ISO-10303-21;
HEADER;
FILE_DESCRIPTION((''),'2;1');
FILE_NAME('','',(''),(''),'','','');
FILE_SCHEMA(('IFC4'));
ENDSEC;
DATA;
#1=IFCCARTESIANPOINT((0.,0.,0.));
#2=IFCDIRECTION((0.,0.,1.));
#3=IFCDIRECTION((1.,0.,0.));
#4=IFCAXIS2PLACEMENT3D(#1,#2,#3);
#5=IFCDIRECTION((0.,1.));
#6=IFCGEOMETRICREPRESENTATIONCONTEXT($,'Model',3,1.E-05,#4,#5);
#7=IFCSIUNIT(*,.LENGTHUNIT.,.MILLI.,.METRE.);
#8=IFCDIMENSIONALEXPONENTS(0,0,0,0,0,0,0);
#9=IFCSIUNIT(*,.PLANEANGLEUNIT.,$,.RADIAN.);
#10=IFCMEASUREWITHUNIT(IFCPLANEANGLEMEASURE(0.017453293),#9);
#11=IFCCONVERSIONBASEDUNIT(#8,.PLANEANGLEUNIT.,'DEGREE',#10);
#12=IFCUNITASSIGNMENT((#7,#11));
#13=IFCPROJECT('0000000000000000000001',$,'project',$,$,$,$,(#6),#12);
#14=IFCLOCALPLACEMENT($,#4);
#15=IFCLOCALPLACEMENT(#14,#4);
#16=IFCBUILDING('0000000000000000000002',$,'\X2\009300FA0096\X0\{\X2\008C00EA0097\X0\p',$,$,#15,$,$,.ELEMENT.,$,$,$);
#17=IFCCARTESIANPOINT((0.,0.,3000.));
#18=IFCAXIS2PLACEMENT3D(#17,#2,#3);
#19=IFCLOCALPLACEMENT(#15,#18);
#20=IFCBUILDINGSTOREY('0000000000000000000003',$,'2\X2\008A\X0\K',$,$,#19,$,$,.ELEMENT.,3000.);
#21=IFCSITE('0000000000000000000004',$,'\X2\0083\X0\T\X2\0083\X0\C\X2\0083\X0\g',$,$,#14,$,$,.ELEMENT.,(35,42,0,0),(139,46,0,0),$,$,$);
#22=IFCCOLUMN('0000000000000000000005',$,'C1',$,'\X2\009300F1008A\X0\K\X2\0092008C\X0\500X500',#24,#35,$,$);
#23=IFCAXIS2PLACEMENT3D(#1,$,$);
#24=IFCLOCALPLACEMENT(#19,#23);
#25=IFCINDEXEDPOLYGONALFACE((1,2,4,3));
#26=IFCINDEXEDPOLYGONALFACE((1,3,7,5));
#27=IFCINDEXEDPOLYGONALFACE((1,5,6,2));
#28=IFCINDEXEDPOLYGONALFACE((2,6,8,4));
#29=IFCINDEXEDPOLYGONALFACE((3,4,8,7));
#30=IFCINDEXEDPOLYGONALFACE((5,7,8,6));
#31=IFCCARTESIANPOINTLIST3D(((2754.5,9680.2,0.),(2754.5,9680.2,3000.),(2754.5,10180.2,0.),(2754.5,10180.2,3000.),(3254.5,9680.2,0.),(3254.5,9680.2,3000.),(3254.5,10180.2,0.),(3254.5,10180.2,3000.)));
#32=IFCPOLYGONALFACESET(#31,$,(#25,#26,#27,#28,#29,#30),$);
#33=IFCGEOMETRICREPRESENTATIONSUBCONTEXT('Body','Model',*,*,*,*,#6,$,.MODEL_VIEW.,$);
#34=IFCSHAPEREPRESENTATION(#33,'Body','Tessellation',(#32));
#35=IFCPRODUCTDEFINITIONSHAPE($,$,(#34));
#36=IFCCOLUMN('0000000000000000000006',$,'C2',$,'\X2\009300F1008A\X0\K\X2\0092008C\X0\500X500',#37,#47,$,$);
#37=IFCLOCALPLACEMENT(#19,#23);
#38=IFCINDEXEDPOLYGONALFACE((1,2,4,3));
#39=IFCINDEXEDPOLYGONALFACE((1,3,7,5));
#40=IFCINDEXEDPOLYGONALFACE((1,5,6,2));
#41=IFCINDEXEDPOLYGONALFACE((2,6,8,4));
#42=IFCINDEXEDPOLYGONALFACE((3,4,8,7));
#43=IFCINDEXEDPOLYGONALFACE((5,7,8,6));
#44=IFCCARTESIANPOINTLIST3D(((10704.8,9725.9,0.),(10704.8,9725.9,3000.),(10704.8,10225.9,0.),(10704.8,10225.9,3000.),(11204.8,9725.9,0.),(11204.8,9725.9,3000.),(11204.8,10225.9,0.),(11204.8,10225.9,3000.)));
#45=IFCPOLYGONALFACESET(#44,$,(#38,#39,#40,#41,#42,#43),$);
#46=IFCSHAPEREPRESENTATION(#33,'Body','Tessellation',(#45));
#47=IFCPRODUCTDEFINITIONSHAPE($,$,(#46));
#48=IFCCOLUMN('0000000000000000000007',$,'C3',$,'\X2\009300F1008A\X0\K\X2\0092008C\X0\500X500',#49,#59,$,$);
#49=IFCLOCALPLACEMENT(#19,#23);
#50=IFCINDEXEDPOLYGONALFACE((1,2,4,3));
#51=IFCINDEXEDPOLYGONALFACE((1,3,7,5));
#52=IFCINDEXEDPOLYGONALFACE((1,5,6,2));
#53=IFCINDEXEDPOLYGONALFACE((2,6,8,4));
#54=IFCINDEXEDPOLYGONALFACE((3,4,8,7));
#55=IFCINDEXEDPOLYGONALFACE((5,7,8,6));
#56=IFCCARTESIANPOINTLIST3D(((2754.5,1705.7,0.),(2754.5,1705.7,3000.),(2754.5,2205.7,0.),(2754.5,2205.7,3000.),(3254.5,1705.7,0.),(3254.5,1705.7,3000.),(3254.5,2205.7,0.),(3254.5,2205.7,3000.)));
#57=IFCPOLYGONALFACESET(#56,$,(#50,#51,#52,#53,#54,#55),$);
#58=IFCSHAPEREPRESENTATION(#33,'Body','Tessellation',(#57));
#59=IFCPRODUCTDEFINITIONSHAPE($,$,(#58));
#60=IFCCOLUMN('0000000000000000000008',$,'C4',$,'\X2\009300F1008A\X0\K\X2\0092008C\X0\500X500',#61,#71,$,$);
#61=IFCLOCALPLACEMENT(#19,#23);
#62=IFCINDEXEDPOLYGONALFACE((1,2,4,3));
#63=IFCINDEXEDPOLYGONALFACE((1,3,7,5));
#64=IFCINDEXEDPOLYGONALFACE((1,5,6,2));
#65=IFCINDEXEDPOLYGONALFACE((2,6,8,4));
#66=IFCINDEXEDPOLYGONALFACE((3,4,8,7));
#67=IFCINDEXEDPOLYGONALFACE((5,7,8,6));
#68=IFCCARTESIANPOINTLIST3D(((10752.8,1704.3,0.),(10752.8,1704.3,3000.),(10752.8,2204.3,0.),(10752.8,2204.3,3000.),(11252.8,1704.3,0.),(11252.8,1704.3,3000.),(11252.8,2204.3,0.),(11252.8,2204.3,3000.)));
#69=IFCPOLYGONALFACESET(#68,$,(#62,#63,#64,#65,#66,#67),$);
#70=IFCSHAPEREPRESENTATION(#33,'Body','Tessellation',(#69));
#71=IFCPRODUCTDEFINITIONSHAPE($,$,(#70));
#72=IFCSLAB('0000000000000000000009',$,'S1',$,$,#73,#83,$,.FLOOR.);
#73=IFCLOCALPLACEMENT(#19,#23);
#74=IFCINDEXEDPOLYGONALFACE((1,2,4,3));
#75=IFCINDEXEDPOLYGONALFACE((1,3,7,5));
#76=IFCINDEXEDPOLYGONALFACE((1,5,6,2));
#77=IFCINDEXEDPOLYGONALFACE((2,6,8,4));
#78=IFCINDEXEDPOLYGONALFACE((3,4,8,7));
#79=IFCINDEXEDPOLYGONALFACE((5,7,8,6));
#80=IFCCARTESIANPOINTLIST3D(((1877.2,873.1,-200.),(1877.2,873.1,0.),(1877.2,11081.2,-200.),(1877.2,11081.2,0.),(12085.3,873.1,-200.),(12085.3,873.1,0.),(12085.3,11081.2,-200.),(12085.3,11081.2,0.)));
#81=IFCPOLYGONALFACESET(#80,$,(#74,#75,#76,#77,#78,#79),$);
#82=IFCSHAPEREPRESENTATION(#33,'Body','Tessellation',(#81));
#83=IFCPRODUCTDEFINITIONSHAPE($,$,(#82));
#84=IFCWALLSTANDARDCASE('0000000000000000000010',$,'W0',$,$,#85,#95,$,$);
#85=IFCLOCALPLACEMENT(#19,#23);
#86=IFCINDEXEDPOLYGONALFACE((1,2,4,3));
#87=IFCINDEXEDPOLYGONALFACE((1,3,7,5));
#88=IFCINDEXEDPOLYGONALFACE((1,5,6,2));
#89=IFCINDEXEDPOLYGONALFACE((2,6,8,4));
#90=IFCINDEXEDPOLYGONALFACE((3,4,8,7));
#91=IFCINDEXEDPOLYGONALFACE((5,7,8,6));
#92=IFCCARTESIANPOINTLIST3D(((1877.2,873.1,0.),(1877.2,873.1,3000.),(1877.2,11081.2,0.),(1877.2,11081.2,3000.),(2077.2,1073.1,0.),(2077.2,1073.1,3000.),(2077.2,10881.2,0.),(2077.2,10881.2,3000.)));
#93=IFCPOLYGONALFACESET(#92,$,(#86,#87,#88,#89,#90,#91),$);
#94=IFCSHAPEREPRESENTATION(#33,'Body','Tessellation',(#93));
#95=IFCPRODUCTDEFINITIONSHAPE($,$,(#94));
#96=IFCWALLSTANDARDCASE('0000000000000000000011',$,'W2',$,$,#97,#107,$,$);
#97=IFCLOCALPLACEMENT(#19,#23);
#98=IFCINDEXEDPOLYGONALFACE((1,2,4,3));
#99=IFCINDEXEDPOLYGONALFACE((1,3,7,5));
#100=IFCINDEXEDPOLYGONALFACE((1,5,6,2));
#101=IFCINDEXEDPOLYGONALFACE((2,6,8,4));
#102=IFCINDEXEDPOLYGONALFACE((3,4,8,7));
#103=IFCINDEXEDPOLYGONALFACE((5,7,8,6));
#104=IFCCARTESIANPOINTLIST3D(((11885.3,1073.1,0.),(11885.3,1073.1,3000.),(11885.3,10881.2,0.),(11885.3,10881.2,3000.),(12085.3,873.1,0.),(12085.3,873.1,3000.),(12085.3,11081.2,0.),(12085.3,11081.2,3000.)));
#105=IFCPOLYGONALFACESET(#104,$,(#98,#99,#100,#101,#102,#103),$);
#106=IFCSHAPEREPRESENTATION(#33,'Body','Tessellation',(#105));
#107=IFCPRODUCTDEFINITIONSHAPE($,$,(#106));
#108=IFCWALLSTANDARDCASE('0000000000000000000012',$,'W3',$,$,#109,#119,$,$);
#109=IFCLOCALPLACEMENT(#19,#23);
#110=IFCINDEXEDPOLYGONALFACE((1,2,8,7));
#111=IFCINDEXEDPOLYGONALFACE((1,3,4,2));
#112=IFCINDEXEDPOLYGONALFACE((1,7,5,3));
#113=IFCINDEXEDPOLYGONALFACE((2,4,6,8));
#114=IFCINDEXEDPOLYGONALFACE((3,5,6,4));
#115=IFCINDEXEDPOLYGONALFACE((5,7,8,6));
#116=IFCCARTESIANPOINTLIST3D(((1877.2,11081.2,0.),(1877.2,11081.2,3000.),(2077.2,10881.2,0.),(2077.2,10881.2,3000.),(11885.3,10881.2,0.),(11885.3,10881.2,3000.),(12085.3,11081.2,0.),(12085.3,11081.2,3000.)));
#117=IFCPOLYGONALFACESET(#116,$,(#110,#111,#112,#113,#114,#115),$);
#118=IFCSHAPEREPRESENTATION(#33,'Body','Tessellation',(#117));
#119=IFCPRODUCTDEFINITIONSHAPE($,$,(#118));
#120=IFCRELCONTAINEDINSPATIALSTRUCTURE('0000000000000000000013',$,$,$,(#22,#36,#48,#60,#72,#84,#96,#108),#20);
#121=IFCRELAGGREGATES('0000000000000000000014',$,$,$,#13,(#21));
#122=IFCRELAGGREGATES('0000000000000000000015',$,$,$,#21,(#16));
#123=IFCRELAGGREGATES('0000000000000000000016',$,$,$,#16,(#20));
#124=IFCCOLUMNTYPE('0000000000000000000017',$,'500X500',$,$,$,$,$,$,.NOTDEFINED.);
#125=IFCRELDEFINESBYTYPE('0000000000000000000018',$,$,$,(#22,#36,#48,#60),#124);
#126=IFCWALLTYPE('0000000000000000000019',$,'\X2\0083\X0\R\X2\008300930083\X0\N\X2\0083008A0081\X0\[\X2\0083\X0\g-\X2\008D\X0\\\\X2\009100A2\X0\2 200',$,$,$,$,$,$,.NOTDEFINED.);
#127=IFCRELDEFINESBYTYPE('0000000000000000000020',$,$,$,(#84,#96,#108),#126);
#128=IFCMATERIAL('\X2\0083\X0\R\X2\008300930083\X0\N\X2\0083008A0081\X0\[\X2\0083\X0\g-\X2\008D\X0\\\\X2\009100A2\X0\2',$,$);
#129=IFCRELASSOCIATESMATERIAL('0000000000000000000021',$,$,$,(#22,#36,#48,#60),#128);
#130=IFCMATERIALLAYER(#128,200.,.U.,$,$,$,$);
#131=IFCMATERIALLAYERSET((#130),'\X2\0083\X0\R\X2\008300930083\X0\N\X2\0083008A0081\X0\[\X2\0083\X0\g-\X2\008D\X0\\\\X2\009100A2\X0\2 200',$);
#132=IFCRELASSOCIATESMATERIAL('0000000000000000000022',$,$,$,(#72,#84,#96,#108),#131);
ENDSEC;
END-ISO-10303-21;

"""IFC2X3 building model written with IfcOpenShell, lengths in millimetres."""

from ifc_helpers import new_model, entity, si_unit, converted_unit, direction, frame, origin_with_axes, origin_2d_with_axis, place, context, subcontext, project, spatial, polyline, rectangle, outline, extrude, material, layer, layer_set, layer_usage, type_object, element, save


model = new_model("IFC2X3")

# Units and contexts
model_context = context("Model", 3, precision=1e-05, world=origin_with_axes(), true_north=direction((0.0, 1.0)))
body_context = subcontext(model_context, "Body", "Model", "MODEL_VIEW")
ifc_project = project(units=[si_unit("LENGTHUNIT", "METRE", prefix="MILLI"), converted_unit("PLANEANGLEUNIT", "DEGREE", entity("IfcPlaneAngleMeasure", 0.017453293), si_unit("PLANEANGLEUNIT", "RADIAN"), dimensions=[0, 0, 0, 0, 0, 0, 0])], contexts=[model_context])

# Site, building, storey
site_placement = place(None, origin_with_axes())
site = spatial("IfcSite", under=ifc_project, at=site_placement, Name="\u0083T\u0083C\u0083g", CompositionType="ELEMENT", RefLatitude=(35, 42, 0, 0), RefLongitude=(139, 46, 0, 0))
building_placement = place(site_placement, origin_with_axes())
building = spatial("IfcBuilding", under=site, at=building_placement, Name="\u0093ú\u0096{\u008cê\u0097p", CompositionType="ELEMENT")
storey_placement = place(building_placement, frame((0.0, 0.0, 3000.0), z_axis=(0.0, 0.0, 1.0), x_axis=(1.0, 0.0, 0.0)))
storey = spatial("IfcBuildingStorey", under=building, at=storey_placement, Name="2\u008aK", CompositionType="ELEMENT", Elevation=3000.0)

# Columns
ifc_material = material(Name="\u0083R\u0083\u0093\u0083N\u0083\u008a\u0081[\u0083g-\u008d\\\u0091¢2")
column_type = type_object("IfcColumnType", Name="500X500", PredefinedType="NOTDEFINED")
for number, where, z_axis, x_axis, name in (
    (1, (3004.5, 9930.2, 0.0), (0.0, 0.0, 1.0), (1.0, 0.0, 0.0), "C1"),
    (2, (10954.8, 9975.9, 0.0), (0.0, 0.0, 1.0), (1.0, 0.0, 0.0), "C2"),
    (3, (3004.5, 1955.7, 0.0), (0.0, 0.0, 1.0), (1.0, 0.0, 0.0), "C3"),
    (4, (11002.8, 1954.3, 0.0), (0.0, 0.0, 1.0), (1.0, 0.0, 0.0), "C4"),
):
    element("IfcColumn", number, at=place(storey_placement, frame(where, z_axis=z_axis, x_axis=x_axis)), inside=storey, type_object=column_type, material=ifc_material, Name=name, ObjectType="\u0093ñ\u008aK\u0092\u008c500X500", context=body_context, shape_type="SweptSolid", body=[
        extrude(rectangle(XDim=500.0, YDim=500.0, at=origin_2d_with_axis()), origin_with_axes(), (0.0, 0.0, 1.0), 3000.0),
    ])

# Slab
ifc_layer = layer(ifc_material, 200.0, ventilated="UNKNOWN")
ifc_layer_set = layer_set([ifc_layer], Name="\u0083R\u0083\u0093\u0083N\u0083\u008a\u0081[\u0083g-\u008d\\\u0091¢2 200")
ifc_layer_usage_1 = layer_usage(ifc_layer_set, "AXIS3", "NEGATIVE", 200.0)
slab_1_placement = place(storey_placement, frame((1877.2, 11081.2, -200.0), z_axis=(0.0, 0.0, 1.0), x_axis=(1.0, 0.0, 0.0)))
element("IfcSlab", 5, at=slab_1_placement, inside=storey, material=ifc_layer_usage_1, Name="S1", PredefinedType="FLOOR", context=body_context, shape_type="SweptSolid", body=[
    extrude(outline(polyline([(0.0, 0.0), (0.0, -10208.1), (10208.1, -10208.1), (10208.1, 0.0), (0.0, 0.0)])), origin_with_axes(), (0.0, 0.0, 1.0), 200.0),
])

# Wall
ifc_layer_usage_2 = layer_usage(ifc_layer_set, "AXIS2", "NEGATIVE", 100.0)
wall_type = type_object("IfcWallType", Name="\u0083R\u0083\u0093\u0083N\u0083\u008a\u0081[\u0083g-\u008d\\\u0091¢2 200", PredefinedType="NOTDEFINED")
wall_1_placement = place(storey_placement, frame((1977.2, 10981.2, 0.0), z_axis=(0.0, 0.0, 1.0), x_axis=(0.0, -1.0, 0.0)))
element("IfcWallStandardCase", 6, at=wall_1_placement, inside=storey, type_object=wall_type, material=ifc_layer_usage_2, Name="W0", context=body_context, shape_type="SweptSolid", body=[
    extrude(outline(polyline([(-100.0, -100.0), (10108.1, -100.0), (9908.1, 100.0), (100.0, 100.0), (-100.0, -100.0)])), origin_with_axes(), (0.0, 0.0, 1.0), 3000.0),
])

# Walls
ifc_layer_usage_3 = layer_usage(ifc_layer_set, "AXIS2", "NEGATIVE", 100.0)
wall_2_placement = place(storey_placement, frame((11985.3, 973.1, 0.0), z_axis=(0.0, 0.0, 1.0), x_axis=(0.0, 1.0, 0.0)))
element("IfcWallStandardCase", 7, at=wall_2_placement, inside=storey, type_object=wall_type, material=ifc_layer_usage_3, Name="W2", context=body_context, shape_type="SweptSolid", body=[
    extrude(outline(polyline([(-100.0, -100.0), (10108.1, -100.0), (9908.1, 100.0), (100.0, 100.0), (-100.0, -100.0)])), origin_with_axes(), (0.0, 0.0, 1.0), 3000.0),
])
ifc_layer_usage_4 = layer_usage(ifc_layer_set, "AXIS2", "NEGATIVE", 100.0)
wall_3_placement = place(storey_placement, frame((11985.3, 10981.2, 0.0), z_axis=(0.0, 0.0, 1.0), x_axis=(-1.0, 0.0, 0.0)))
element("IfcWallStandardCase", 8, at=wall_3_placement, inside=storey, type_object=wall_type, material=ifc_layer_usage_4, Name="W3", context=body_context, shape_type="SweptSolid", body=[
    extrude(outline(polyline([(-100.0, -100.0), (10108.1, -100.0), (9908.1, 100.0), (100.0, 100.0), (-100.0, -100.0)])), origin_with_axes(), (0.0, 0.0, 1.0), 3000.0),
])

save(model, "model.ifc")
